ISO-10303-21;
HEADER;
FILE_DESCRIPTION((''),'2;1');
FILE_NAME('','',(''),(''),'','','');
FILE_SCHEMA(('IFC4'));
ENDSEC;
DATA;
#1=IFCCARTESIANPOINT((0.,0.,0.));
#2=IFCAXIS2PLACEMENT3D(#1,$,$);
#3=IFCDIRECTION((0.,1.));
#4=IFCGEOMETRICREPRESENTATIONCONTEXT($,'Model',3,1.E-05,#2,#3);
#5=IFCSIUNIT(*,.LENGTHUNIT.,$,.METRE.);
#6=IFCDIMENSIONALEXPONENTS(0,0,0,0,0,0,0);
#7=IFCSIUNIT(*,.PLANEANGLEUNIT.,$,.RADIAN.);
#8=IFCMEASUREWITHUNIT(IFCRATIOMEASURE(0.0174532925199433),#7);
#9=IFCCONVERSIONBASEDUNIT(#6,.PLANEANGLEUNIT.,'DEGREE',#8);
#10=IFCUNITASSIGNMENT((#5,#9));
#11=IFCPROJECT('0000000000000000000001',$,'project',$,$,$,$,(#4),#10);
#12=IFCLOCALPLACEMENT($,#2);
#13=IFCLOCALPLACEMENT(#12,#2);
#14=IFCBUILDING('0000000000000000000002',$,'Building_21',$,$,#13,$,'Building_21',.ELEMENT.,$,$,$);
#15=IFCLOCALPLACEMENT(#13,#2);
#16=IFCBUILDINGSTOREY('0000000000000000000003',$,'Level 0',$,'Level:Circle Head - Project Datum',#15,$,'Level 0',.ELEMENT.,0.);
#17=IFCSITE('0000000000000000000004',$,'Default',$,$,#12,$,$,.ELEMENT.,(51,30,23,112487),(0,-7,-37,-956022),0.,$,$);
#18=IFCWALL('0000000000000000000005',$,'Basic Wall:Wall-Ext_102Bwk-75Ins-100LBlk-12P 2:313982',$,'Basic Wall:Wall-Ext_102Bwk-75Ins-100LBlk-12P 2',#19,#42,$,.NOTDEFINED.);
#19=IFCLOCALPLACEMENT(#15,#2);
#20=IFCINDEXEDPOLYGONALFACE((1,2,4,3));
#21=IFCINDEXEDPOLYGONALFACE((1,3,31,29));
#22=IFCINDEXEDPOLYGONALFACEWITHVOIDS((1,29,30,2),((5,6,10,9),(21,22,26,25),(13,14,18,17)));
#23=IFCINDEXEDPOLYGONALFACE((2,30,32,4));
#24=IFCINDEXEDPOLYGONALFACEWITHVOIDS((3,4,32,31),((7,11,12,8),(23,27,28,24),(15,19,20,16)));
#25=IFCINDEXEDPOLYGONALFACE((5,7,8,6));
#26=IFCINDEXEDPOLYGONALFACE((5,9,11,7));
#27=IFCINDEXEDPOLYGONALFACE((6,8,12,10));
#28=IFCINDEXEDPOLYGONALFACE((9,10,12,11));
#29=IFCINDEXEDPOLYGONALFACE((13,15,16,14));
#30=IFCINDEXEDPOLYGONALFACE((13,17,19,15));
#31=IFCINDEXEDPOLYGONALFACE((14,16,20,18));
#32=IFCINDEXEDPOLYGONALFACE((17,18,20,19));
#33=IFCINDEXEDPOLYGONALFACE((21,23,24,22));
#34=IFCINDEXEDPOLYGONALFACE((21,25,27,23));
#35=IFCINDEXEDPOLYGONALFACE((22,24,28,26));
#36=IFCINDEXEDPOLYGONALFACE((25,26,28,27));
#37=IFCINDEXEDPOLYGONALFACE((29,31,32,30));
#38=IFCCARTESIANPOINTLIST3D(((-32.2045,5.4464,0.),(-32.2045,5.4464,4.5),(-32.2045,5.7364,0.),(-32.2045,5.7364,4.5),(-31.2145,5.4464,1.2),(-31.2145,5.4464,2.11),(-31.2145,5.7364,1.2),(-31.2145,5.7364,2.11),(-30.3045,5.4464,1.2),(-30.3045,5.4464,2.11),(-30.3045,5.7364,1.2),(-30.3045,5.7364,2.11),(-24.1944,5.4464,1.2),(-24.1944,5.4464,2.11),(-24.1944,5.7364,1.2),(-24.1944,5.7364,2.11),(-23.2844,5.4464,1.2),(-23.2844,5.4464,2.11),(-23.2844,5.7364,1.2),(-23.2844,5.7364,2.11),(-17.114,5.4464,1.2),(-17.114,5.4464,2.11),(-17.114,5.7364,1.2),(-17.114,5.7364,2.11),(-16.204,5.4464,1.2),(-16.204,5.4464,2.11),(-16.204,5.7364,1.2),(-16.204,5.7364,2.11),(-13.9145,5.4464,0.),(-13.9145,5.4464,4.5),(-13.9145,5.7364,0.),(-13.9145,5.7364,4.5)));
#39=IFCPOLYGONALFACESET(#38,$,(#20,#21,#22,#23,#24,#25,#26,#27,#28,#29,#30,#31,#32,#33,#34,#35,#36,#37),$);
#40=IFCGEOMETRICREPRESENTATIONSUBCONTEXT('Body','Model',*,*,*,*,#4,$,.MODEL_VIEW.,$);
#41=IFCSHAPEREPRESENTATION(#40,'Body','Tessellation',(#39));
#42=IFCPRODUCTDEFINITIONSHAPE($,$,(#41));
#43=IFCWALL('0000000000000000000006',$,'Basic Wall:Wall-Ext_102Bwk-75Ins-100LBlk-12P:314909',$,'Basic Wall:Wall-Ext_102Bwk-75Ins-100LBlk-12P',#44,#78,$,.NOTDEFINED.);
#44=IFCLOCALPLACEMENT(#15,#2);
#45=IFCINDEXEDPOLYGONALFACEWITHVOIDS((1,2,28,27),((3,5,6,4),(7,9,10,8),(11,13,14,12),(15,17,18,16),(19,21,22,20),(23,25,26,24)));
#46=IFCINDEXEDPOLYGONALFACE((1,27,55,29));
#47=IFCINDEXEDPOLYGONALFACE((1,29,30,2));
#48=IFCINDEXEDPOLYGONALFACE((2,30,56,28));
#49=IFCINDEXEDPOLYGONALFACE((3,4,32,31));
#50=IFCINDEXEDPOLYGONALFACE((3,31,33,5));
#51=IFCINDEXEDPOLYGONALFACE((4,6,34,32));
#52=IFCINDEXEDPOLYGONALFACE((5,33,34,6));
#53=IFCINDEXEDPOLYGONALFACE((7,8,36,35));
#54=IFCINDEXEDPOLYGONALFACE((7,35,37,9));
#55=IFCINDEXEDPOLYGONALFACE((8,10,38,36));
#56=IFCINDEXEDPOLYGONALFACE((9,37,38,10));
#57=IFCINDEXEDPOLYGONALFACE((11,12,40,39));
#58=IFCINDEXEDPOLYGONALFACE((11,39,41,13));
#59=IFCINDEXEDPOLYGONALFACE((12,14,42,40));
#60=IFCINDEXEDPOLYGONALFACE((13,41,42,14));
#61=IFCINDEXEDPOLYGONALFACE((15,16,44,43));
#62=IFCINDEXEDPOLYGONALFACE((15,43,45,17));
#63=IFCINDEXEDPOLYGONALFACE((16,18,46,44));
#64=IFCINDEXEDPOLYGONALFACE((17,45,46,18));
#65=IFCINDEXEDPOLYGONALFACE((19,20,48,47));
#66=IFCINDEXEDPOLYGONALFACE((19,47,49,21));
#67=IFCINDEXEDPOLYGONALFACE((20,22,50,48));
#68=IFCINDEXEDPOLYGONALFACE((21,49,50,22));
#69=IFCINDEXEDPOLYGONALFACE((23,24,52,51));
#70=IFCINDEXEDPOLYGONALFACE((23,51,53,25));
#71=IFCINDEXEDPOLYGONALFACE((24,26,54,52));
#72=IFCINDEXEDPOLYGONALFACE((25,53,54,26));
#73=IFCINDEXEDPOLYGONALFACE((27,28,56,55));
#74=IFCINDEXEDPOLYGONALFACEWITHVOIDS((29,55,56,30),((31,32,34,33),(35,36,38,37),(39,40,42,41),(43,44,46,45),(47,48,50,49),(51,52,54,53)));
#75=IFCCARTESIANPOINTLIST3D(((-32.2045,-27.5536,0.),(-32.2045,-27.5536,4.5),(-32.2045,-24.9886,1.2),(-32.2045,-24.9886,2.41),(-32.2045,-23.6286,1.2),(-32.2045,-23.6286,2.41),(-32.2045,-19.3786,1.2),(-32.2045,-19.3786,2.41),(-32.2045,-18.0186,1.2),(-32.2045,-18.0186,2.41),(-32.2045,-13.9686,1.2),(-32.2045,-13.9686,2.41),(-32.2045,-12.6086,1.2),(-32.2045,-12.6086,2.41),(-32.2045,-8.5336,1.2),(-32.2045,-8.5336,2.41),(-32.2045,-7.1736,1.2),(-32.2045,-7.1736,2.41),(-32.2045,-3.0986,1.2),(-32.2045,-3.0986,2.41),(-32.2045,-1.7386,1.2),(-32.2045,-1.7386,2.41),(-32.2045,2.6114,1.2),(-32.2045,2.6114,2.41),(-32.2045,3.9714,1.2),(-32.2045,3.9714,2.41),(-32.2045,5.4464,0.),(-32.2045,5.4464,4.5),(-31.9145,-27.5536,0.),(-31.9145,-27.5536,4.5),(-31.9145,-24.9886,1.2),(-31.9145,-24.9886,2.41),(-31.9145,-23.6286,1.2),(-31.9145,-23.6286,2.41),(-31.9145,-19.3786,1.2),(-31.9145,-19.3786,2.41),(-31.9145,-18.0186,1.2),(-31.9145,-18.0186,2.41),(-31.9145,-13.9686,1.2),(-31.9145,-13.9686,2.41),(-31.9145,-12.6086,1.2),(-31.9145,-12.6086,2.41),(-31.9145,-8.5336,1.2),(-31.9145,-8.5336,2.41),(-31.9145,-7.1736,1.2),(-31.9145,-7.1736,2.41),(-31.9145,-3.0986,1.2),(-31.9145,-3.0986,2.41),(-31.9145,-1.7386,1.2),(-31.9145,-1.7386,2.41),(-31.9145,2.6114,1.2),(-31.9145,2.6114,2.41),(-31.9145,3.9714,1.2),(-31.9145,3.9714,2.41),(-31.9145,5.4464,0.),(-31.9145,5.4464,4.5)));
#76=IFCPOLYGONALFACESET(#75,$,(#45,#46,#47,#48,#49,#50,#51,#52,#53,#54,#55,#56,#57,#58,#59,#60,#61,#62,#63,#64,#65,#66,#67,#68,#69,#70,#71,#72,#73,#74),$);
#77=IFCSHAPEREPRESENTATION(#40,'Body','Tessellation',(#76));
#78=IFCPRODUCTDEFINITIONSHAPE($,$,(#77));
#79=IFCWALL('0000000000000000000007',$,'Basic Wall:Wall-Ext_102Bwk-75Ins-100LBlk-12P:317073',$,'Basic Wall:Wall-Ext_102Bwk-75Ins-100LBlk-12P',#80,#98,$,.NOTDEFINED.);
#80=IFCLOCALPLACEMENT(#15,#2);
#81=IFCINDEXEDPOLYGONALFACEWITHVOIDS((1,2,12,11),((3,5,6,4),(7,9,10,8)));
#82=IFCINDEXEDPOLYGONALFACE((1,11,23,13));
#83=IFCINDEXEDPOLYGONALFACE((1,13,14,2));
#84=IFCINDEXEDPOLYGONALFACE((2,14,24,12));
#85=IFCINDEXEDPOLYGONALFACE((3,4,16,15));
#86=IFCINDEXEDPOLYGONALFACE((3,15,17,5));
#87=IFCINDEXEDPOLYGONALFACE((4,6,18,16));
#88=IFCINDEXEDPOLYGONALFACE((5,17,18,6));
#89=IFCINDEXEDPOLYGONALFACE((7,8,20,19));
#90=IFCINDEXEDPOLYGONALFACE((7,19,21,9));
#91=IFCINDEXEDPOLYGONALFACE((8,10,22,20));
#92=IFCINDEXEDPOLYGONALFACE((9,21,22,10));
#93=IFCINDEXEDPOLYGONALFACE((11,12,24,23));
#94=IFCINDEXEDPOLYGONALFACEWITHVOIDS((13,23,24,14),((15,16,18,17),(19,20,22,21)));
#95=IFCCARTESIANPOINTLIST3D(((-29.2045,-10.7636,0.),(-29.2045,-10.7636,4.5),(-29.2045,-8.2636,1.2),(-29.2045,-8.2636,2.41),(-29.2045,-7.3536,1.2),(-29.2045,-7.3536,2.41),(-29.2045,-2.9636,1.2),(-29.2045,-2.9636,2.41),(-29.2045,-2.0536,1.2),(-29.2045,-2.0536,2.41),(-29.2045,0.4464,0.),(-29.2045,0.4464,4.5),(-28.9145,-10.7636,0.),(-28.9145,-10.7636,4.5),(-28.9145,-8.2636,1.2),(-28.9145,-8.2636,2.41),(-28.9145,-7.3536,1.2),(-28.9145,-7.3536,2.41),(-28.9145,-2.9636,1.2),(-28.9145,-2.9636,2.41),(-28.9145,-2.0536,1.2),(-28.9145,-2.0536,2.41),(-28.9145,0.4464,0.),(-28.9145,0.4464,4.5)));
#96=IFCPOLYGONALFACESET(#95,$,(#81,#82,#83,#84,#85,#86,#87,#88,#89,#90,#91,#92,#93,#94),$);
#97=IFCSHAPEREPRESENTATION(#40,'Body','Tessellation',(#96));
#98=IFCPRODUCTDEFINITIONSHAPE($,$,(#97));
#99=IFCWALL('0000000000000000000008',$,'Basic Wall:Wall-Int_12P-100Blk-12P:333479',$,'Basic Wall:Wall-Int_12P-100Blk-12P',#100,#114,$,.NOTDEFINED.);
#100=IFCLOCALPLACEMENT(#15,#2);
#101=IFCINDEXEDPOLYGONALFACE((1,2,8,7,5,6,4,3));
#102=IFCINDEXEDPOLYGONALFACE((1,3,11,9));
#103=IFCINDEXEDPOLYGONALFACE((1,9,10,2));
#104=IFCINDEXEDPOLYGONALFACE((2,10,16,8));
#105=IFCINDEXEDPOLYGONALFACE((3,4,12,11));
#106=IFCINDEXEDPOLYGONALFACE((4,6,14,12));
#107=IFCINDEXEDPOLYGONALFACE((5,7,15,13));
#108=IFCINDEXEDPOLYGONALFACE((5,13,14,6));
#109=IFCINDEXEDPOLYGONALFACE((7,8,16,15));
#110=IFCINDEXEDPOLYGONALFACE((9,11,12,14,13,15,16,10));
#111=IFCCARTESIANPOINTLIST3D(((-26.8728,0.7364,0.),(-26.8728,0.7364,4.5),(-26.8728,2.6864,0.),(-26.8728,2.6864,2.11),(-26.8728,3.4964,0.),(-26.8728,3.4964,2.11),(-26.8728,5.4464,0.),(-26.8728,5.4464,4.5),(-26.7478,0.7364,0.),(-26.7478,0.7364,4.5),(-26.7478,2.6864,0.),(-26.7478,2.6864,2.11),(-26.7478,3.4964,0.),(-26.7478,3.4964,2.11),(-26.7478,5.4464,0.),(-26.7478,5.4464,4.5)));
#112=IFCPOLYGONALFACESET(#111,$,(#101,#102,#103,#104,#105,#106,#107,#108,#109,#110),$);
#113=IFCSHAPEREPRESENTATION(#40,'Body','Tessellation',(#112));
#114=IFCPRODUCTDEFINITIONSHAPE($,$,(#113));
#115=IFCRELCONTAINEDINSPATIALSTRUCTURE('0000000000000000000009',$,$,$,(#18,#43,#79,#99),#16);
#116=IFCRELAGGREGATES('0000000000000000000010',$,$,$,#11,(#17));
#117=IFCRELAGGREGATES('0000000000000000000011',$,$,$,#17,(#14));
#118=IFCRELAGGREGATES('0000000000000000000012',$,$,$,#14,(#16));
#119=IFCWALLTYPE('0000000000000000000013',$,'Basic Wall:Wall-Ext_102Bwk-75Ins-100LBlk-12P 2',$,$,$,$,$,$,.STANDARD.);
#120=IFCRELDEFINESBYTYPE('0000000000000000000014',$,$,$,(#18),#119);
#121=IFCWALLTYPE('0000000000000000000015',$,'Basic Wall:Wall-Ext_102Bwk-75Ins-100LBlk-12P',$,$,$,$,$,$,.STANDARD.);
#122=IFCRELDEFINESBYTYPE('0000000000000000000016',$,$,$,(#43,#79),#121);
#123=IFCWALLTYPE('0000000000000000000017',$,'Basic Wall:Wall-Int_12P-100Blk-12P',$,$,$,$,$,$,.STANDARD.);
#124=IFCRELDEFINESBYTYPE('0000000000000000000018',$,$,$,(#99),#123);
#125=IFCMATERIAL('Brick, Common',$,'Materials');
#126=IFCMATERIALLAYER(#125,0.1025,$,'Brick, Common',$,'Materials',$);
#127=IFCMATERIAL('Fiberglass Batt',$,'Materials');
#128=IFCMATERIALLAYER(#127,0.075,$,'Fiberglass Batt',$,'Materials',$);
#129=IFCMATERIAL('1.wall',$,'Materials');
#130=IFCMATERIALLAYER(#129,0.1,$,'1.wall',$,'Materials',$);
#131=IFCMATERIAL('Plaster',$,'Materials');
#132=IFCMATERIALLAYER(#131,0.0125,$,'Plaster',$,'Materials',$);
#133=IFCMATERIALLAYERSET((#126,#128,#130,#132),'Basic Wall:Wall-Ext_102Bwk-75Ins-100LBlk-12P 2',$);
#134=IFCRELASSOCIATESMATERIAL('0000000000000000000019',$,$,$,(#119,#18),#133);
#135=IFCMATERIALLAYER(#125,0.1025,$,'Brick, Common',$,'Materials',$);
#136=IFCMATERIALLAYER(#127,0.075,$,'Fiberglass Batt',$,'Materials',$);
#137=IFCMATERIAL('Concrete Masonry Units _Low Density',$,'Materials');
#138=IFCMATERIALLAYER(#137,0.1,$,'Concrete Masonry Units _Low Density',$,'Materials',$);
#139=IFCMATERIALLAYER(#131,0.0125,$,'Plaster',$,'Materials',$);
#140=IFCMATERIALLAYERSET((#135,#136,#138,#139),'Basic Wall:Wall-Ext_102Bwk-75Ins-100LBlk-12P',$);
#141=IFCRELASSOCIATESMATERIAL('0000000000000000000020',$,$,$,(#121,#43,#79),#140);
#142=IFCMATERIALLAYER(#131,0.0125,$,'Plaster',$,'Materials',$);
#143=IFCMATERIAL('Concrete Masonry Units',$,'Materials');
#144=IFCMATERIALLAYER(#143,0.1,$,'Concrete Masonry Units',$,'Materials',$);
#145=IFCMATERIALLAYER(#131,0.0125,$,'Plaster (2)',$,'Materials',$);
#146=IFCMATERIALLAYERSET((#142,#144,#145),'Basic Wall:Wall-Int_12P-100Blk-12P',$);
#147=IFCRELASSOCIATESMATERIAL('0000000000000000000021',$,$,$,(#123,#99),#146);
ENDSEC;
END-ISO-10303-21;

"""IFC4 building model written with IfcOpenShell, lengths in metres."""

from ifc_helpers import new_model, entity, si_unit, converted_unit, direction, frame, frame_2d, origin, place, context, subcontext, project, spatial, rectangle, extrude, material, layer, layer_set, layer_usage, type_object, element, save


model = new_model("IFC4")

# Units and contexts
model_context = context("Model", 3, precision=1e-05, world=origin(), true_north=direction((0.0, 1.0)))
body_context = subcontext(model_context, "Body", "Model", "MODEL_VIEW")
ifc_project = project(units=[si_unit("LENGTHUNIT", "METRE"), converted_unit("PLANEANGLEUNIT", "DEGREE", entity("IfcRatioMeasure", 0.0174532925199433), si_unit("PLANEANGLEUNIT", "RADIAN"), dimensions=[0, 0, 0, 0, 0, 0, 0])], contexts=[model_context])

# Site, building, storey
site_placement = place(None, origin())
site = spatial("IfcSite", under=ifc_project, at=site_placement, Name="Default", CompositionType="ELEMENT", RefLatitude=(51, 30, 23, 112487), RefLongitude=(0, -7, -37, -956022), RefElevation=0.0)
building_placement = place(site_placement, origin())
building = spatial("IfcBuilding", under=site, at=building_placement, Name="Building_21", LongName="Building_21", CompositionType="ELEMENT")
storey_placement = place(building_placement, origin())
storey = spatial("IfcBuildingStorey", under=building, at=storey_placement, Name="Level 0", ObjectType="Level:Circle Head - Project Datum", LongName="Level 0", CompositionType="ELEMENT", Elevation=0.0)

# Walls, openings
ifc_material_1 = material(Name="Brick, Common", Category="Materials")
ifc_layer_1 = layer(ifc_material_1, 0.1025, Name="Brick, Common", Category="Materials")
ifc_material_2 = material(Name="Fiberglass Batt", Category="Materials")
ifc_layer_2 = layer(ifc_material_2, 0.075, Name="Fiberglass Batt", Category="Materials")
ifc_material_3 = material(Name="1.wall", Category="Materials")
ifc_layer_3 = layer(ifc_material_3, 0.1, Name="1.wall", Category="Materials")
ifc_material_4 = material(Name="Plaster", Category="Materials")
ifc_layer_4 = layer(ifc_material_4, 0.0125, Name="Plaster", Category="Materials")
ifc_layer_set_1 = layer_set([ifc_layer_1, ifc_layer_2, ifc_layer_3, ifc_layer_4], Name="Basic Wall:Wall-Ext_102Bwk-75Ins-100LBlk-12P 2")
ifc_layer_usage_1 = layer_usage(ifc_layer_set_1, "AXIS2", "NEGATIVE", 0.145)
wall_type_1 = type_object("IfcWallType", Name="Basic Wall:Wall-Ext_102Bwk-75Ins-100LBlk-12P 2", PredefinedType="STANDARD", material=ifc_layer_set_1)
wall_1_placement = place(storey_placement, frame((-32.2045, 5.5914, 0.0)))
wall_1 = element("IfcWall", 1, at=wall_1_placement, inside=storey, type_object=wall_type_1, material=ifc_layer_usage_1, Name="Basic Wall:Wall-Ext_102Bwk-75Ins-100LBlk-12P 2:313982", ObjectType="Basic Wall:Wall-Ext_102Bwk-75Ins-100LBlk-12P 2", PredefinedType="NOTDEFINED", context=body_context, shape_type="SweptSolid", body=[
    extrude(rectangle(XDim=18.29, YDim=0.29, at=frame_2d((9.145, 0.0), x_axis=(-1.0, 0.0))), origin(), (0.0, 0.0, 1.0), 4.5),
])
opening_1_placement = place(wall_1_placement, frame((8.0101, -0.145, 1.2)))
element("IfcOpeningElement", 2, at=opening_1_placement, cuts=wall_1, PredefinedType="OPENING", context=body_context, shape_type="SweptSolid", body=[
    extrude(rectangle(XDim=0.91, YDim=0.91, at=frame_2d((0.455, 0.455), x_axis=(-1.0, 0.0))), frame((0.0, 0.0, 0.0), z_axis=(0.0, 1.0, 0.0), x_axis=(0.0, 0.0, 1.0)), (0.0, 0.0, 1.0), 0.29),
])
opening_2_placement = place(wall_1_placement, frame((15.0905, -0.145, 1.2)))
element("IfcOpeningElement", 3, at=opening_2_placement, cuts=wall_1, PredefinedType="OPENING", context=body_context, shape_type="SweptSolid", body=[
    extrude(rectangle(XDim=0.91, YDim=0.91, at=frame_2d((0.455, 0.455), x_axis=(-1.0, 0.0))), frame((0.0, 0.0, 0.0), z_axis=(0.0, 1.0, 0.0), x_axis=(0.0, 0.0, 1.0)), (0.0, 0.0, 1.0), 0.29),
])
opening_3_placement = place(wall_1_placement, frame((0.99, -0.145, 1.2)))
element("IfcOpeningElement", 4, at=opening_3_placement, cuts=wall_1, PredefinedType="OPENING", context=body_context, shape_type="SweptSolid", body=[
    extrude(rectangle(XDim=0.91, YDim=0.91, at=frame_2d((0.455, 0.455), x_axis=(-1.0, 0.0))), frame((0.0, 0.0, 0.0), z_axis=(0.0, 1.0, 0.0), x_axis=(0.0, 0.0, 1.0)), (0.0, 0.0, 1.0), 0.29),
])
ifc_layer_5 = layer(ifc_material_1, 0.1025, Name="Brick, Common", Category="Materials")
ifc_layer_6 = layer(ifc_material_2, 0.075, Name="Fiberglass Batt", Category="Materials")
ifc_material_5 = material(Name="Concrete Masonry Units _Low Density", Category="Materials")
ifc_layer_7 = layer(ifc_material_5, 0.1, Name="Concrete Masonry Units _Low Density", Category="Materials")
ifc_layer_8 = layer(ifc_material_4, 0.0125, Name="Plaster", Category="Materials")
ifc_layer_set_2 = layer_set([ifc_layer_5, ifc_layer_6, ifc_layer_7, ifc_layer_8], Name="Basic Wall:Wall-Ext_102Bwk-75Ins-100LBlk-12P")
ifc_layer_usage_2 = layer_usage(ifc_layer_set_2, "AXIS2", "NEGATIVE", 0.145)
wall_type_2 = type_object("IfcWallType", Name="Basic Wall:Wall-Ext_102Bwk-75Ins-100LBlk-12P", PredefinedType="STANDARD", material=ifc_layer_set_2)
wall_2_placement = place(storey_placement, frame((-32.0595, 5.4464, 0.0), z_axis=(0.0, 0.0, 1.0), x_axis=(0.0, -1.0, 0.0)))
wall_2 = element("IfcWall", 5, at=wall_2_placement, inside=storey, type_object=wall_type_2, material=ifc_layer_usage_2, Name="Basic Wall:Wall-Ext_102Bwk-75Ins-100LBlk-12P:314909", ObjectType="Basic Wall:Wall-Ext_102Bwk-75Ins-100LBlk-12P", PredefinedType="NOTDEFINED", context=body_context, shape_type="SweptSolid", body=[
    extrude(rectangle(XDim=33.0, YDim=0.29, at=frame_2d((16.5, 0.0), x_axis=(-1.0, 0.0))), origin(), (0.0, 0.0, 1.0), 4.5),
])
opening_4_placement = place(wall_2_placement, frame((30.435, 0.145, 1.2)))
element("IfcOpeningElement", 6, at=opening_4_placement, cuts=wall_2, PredefinedType="OPENING", context=body_context, shape_type="SweptSolid", body=[
    extrude(rectangle(XDim=1.21, YDim=1.36, at=frame_2d((0.605, 0.68), x_axis=(-1.0, 0.0))), frame((0.0, 0.0, 0.0), z_axis=(0.0, -1.0, 0.0), x_axis=(0.0, 0.0, 1.0)), (0.0, 0.0, 1.0), 0.29),
])
opening_5_placement = place(wall_2_placement, frame((24.825, 0.145, 1.2)))
element("IfcOpeningElement", 7, at=opening_5_placement, cuts=wall_2, PredefinedType="OPENING", context=body_context, shape_type="SweptSolid", body=[
    extrude(rectangle(XDim=1.21, YDim=1.36, at=frame_2d((0.605, 0.68), x_axis=(-1.0, 0.0))), frame((0.0, 0.0, 0.0), z_axis=(0.0, -1.0, 0.0), x_axis=(0.0, 0.0, 1.0)), (0.0, 0.0, 1.0), 0.29),
])
opening_6_placement = place(wall_2_placement, frame((19.415, 0.145, 1.2)))
element("IfcOpeningElement", 8, at=opening_6_placement, cuts=wall_2, PredefinedType="OPENING", context=body_context, shape_type="SweptSolid", body=[
    extrude(rectangle(XDim=1.21, YDim=1.36, at=frame_2d((0.605, 0.68), x_axis=(-1.0, 0.0))), frame((0.0, 0.0, 0.0), z_axis=(0.0, -1.0, 0.0), x_axis=(0.0, 0.0, 1.0)), (0.0, 0.0, 1.0), 0.29),
])
opening_7_placement = place(wall_2_placement, frame((2.835, 0.145, 1.2)))
element("IfcOpeningElement", 9, at=opening_7_placement, cuts=wall_2, PredefinedType="OPENING", context=body_context, shape_type="SweptSolid", body=[
    extrude(rectangle(XDim=1.21, YDim=1.36, at=frame_2d((0.605, 0.68), x_axis=(-1.0, 0.0))), frame((0.0, 0.0, 0.0), z_axis=(0.0, -1.0, 0.0), x_axis=(0.0, 0.0, 1.0)), (0.0, 0.0, 1.0), 0.29),
])
opening_8_placement = place(wall_2_placement, frame((8.545, 0.145, 1.2)))
element("IfcOpeningElement", 10, at=opening_8_placement, cuts=wall_2, PredefinedType="OPENING", context=body_context, shape_type="SweptSolid", body=[
    extrude(rectangle(XDim=1.21, YDim=1.36, at=frame_2d((0.605, 0.68), x_axis=(-1.0, 0.0))), frame((0.0, 0.0, 0.0), z_axis=(0.0, -1.0, 0.0), x_axis=(0.0, 0.0, 1.0)), (0.0, 0.0, 1.0), 0.29),
])
opening_9_placement = place(wall_2_placement, frame((13.98, 0.145, 1.2)))
element("IfcOpeningElement", 11, at=opening_9_placement, cuts=wall_2, PredefinedType="OPENING", context=body_context, shape_type="SweptSolid", body=[
    extrude(rectangle(XDim=1.21, YDim=1.36, at=frame_2d((0.605, 0.68), x_axis=(-1.0, 0.0))), frame((0.0, 0.0, 0.0), z_axis=(0.0, -1.0, 0.0), x_axis=(0.0, 0.0, 1.0)), (0.0, 0.0, 1.0), 0.29),
])
ifc_layer_usage_3 = layer_usage(ifc_layer_set_2, "AXIS2", "NEGATIVE", 0.145)
wall_3_placement = place(storey_placement, frame((-29.0595, 0.4464, 0.0), z_axis=(0.0, 0.0, 1.0), x_axis=(0.0, -1.0, 0.0)))
wall_3 = element("IfcWall", 12, at=wall_3_placement, inside=storey, type_object=wall_type_2, material=ifc_layer_usage_3, Name="Basic Wall:Wall-Ext_102Bwk-75Ins-100LBlk-12P:317073", ObjectType="Basic Wall:Wall-Ext_102Bwk-75Ins-100LBlk-12P", PredefinedType="NOTDEFINED", context=body_context, shape_type="SweptSolid", body=[
    extrude(rectangle(XDim=11.21, YDim=0.29, at=frame_2d((5.605, 0.0), x_axis=(-1.0, 0.0))), origin(), (0.0, 0.0, 1.0), 4.5),
])
opening_10_placement = place(wall_3_placement, frame((2.5, -0.145, 1.2)))
element("IfcOpeningElement", 13, at=opening_10_placement, cuts=wall_3, PredefinedType="OPENING", context=body_context, shape_type="SweptSolid", body=[
    extrude(rectangle(XDim=1.21, YDim=0.91, at=frame_2d((0.605, 0.455), x_axis=(-1.0, 0.0))), frame((0.0, 0.0, 0.0), z_axis=(0.0, 1.0, 0.0), x_axis=(0.0, 0.0, 1.0)), (0.0, 0.0, 1.0), 0.29),
])
opening_11_placement = place(wall_3_placement, frame((7.8, -0.145, 1.2)))
element("IfcOpeningElement", 14, at=opening_11_placement, cuts=wall_3, PredefinedType="OPENING", context=body_context, shape_type="SweptSolid", body=[
    extrude(rectangle(XDim=1.21, YDim=0.91, at=frame_2d((0.605, 0.455), x_axis=(-1.0, 0.0))), frame((0.0, 0.0, 0.0), z_axis=(0.0, 1.0, 0.0), x_axis=(0.0, 0.0, 1.0)), (0.0, 0.0, 1.0), 0.29),
])

# Wall, opening
ifc_layer_9 = layer(ifc_material_4, 0.0125, Name="Plaster", Category="Materials")
ifc_material_6 = material(Name="Concrete Masonry Units", Category="Materials")
ifc_layer_10 = layer(ifc_material_6, 0.1, Name="Concrete Masonry Units", Category="Materials")
ifc_layer_11 = layer(ifc_material_4, 0.0125, Name="Plaster (2)", Category="Materials")
ifc_layer_set_3 = layer_set([ifc_layer_9, ifc_layer_10, ifc_layer_11], Name="Basic Wall:Wall-Int_12P-100Blk-12P")
ifc_layer_usage_4 = layer_usage(ifc_layer_set_3, "AXIS2", "NEGATIVE", 0.0625)
wall_type_3 = type_object("IfcWallType", Name="Basic Wall:Wall-Int_12P-100Blk-12P", PredefinedType="STANDARD", material=ifc_layer_set_3)
wall_4_placement = place(storey_placement, frame((-26.8103, 5.4464, 0.0), z_axis=(0.0, 0.0, 1.0), x_axis=(0.0, -1.0, 0.0)))
wall_4 = element("IfcWall", 15, at=wall_4_placement, inside=storey, type_object=wall_type_3, material=ifc_layer_usage_4, Name="Basic Wall:Wall-Int_12P-100Blk-12P:333479", ObjectType="Basic Wall:Wall-Int_12P-100Blk-12P", PredefinedType="NOTDEFINED", context=body_context, shape_type="SweptSolid", body=[
    extrude(rectangle(XDim=4.71, YDim=0.125, at=frame_2d((2.355, 0.0), x_axis=(1.0, 0.0))), origin(), (0.0, 0.0, 1.0), 4.5),
])
opening_12_placement = place(wall_4_placement, frame((1.95, -0.0625, 0.0)))
element("IfcOpeningElement", 16, at=opening_12_placement, cuts=wall_4, PredefinedType="OPENING", context=body_context, shape_type="SweptSolid", body=[
    extrude(rectangle(XDim=2.11, YDim=0.81, at=frame_2d((1.055, 0.405), x_axis=(1.0, 0.0))), frame((0.0, 0.0, 0.0), z_axis=(0.0, 1.0, 0.0), x_axis=(0.0, 0.0, 1.0)), (0.0, 0.0, 1.0), 0.125),
])

save(model, "model.ifc")
